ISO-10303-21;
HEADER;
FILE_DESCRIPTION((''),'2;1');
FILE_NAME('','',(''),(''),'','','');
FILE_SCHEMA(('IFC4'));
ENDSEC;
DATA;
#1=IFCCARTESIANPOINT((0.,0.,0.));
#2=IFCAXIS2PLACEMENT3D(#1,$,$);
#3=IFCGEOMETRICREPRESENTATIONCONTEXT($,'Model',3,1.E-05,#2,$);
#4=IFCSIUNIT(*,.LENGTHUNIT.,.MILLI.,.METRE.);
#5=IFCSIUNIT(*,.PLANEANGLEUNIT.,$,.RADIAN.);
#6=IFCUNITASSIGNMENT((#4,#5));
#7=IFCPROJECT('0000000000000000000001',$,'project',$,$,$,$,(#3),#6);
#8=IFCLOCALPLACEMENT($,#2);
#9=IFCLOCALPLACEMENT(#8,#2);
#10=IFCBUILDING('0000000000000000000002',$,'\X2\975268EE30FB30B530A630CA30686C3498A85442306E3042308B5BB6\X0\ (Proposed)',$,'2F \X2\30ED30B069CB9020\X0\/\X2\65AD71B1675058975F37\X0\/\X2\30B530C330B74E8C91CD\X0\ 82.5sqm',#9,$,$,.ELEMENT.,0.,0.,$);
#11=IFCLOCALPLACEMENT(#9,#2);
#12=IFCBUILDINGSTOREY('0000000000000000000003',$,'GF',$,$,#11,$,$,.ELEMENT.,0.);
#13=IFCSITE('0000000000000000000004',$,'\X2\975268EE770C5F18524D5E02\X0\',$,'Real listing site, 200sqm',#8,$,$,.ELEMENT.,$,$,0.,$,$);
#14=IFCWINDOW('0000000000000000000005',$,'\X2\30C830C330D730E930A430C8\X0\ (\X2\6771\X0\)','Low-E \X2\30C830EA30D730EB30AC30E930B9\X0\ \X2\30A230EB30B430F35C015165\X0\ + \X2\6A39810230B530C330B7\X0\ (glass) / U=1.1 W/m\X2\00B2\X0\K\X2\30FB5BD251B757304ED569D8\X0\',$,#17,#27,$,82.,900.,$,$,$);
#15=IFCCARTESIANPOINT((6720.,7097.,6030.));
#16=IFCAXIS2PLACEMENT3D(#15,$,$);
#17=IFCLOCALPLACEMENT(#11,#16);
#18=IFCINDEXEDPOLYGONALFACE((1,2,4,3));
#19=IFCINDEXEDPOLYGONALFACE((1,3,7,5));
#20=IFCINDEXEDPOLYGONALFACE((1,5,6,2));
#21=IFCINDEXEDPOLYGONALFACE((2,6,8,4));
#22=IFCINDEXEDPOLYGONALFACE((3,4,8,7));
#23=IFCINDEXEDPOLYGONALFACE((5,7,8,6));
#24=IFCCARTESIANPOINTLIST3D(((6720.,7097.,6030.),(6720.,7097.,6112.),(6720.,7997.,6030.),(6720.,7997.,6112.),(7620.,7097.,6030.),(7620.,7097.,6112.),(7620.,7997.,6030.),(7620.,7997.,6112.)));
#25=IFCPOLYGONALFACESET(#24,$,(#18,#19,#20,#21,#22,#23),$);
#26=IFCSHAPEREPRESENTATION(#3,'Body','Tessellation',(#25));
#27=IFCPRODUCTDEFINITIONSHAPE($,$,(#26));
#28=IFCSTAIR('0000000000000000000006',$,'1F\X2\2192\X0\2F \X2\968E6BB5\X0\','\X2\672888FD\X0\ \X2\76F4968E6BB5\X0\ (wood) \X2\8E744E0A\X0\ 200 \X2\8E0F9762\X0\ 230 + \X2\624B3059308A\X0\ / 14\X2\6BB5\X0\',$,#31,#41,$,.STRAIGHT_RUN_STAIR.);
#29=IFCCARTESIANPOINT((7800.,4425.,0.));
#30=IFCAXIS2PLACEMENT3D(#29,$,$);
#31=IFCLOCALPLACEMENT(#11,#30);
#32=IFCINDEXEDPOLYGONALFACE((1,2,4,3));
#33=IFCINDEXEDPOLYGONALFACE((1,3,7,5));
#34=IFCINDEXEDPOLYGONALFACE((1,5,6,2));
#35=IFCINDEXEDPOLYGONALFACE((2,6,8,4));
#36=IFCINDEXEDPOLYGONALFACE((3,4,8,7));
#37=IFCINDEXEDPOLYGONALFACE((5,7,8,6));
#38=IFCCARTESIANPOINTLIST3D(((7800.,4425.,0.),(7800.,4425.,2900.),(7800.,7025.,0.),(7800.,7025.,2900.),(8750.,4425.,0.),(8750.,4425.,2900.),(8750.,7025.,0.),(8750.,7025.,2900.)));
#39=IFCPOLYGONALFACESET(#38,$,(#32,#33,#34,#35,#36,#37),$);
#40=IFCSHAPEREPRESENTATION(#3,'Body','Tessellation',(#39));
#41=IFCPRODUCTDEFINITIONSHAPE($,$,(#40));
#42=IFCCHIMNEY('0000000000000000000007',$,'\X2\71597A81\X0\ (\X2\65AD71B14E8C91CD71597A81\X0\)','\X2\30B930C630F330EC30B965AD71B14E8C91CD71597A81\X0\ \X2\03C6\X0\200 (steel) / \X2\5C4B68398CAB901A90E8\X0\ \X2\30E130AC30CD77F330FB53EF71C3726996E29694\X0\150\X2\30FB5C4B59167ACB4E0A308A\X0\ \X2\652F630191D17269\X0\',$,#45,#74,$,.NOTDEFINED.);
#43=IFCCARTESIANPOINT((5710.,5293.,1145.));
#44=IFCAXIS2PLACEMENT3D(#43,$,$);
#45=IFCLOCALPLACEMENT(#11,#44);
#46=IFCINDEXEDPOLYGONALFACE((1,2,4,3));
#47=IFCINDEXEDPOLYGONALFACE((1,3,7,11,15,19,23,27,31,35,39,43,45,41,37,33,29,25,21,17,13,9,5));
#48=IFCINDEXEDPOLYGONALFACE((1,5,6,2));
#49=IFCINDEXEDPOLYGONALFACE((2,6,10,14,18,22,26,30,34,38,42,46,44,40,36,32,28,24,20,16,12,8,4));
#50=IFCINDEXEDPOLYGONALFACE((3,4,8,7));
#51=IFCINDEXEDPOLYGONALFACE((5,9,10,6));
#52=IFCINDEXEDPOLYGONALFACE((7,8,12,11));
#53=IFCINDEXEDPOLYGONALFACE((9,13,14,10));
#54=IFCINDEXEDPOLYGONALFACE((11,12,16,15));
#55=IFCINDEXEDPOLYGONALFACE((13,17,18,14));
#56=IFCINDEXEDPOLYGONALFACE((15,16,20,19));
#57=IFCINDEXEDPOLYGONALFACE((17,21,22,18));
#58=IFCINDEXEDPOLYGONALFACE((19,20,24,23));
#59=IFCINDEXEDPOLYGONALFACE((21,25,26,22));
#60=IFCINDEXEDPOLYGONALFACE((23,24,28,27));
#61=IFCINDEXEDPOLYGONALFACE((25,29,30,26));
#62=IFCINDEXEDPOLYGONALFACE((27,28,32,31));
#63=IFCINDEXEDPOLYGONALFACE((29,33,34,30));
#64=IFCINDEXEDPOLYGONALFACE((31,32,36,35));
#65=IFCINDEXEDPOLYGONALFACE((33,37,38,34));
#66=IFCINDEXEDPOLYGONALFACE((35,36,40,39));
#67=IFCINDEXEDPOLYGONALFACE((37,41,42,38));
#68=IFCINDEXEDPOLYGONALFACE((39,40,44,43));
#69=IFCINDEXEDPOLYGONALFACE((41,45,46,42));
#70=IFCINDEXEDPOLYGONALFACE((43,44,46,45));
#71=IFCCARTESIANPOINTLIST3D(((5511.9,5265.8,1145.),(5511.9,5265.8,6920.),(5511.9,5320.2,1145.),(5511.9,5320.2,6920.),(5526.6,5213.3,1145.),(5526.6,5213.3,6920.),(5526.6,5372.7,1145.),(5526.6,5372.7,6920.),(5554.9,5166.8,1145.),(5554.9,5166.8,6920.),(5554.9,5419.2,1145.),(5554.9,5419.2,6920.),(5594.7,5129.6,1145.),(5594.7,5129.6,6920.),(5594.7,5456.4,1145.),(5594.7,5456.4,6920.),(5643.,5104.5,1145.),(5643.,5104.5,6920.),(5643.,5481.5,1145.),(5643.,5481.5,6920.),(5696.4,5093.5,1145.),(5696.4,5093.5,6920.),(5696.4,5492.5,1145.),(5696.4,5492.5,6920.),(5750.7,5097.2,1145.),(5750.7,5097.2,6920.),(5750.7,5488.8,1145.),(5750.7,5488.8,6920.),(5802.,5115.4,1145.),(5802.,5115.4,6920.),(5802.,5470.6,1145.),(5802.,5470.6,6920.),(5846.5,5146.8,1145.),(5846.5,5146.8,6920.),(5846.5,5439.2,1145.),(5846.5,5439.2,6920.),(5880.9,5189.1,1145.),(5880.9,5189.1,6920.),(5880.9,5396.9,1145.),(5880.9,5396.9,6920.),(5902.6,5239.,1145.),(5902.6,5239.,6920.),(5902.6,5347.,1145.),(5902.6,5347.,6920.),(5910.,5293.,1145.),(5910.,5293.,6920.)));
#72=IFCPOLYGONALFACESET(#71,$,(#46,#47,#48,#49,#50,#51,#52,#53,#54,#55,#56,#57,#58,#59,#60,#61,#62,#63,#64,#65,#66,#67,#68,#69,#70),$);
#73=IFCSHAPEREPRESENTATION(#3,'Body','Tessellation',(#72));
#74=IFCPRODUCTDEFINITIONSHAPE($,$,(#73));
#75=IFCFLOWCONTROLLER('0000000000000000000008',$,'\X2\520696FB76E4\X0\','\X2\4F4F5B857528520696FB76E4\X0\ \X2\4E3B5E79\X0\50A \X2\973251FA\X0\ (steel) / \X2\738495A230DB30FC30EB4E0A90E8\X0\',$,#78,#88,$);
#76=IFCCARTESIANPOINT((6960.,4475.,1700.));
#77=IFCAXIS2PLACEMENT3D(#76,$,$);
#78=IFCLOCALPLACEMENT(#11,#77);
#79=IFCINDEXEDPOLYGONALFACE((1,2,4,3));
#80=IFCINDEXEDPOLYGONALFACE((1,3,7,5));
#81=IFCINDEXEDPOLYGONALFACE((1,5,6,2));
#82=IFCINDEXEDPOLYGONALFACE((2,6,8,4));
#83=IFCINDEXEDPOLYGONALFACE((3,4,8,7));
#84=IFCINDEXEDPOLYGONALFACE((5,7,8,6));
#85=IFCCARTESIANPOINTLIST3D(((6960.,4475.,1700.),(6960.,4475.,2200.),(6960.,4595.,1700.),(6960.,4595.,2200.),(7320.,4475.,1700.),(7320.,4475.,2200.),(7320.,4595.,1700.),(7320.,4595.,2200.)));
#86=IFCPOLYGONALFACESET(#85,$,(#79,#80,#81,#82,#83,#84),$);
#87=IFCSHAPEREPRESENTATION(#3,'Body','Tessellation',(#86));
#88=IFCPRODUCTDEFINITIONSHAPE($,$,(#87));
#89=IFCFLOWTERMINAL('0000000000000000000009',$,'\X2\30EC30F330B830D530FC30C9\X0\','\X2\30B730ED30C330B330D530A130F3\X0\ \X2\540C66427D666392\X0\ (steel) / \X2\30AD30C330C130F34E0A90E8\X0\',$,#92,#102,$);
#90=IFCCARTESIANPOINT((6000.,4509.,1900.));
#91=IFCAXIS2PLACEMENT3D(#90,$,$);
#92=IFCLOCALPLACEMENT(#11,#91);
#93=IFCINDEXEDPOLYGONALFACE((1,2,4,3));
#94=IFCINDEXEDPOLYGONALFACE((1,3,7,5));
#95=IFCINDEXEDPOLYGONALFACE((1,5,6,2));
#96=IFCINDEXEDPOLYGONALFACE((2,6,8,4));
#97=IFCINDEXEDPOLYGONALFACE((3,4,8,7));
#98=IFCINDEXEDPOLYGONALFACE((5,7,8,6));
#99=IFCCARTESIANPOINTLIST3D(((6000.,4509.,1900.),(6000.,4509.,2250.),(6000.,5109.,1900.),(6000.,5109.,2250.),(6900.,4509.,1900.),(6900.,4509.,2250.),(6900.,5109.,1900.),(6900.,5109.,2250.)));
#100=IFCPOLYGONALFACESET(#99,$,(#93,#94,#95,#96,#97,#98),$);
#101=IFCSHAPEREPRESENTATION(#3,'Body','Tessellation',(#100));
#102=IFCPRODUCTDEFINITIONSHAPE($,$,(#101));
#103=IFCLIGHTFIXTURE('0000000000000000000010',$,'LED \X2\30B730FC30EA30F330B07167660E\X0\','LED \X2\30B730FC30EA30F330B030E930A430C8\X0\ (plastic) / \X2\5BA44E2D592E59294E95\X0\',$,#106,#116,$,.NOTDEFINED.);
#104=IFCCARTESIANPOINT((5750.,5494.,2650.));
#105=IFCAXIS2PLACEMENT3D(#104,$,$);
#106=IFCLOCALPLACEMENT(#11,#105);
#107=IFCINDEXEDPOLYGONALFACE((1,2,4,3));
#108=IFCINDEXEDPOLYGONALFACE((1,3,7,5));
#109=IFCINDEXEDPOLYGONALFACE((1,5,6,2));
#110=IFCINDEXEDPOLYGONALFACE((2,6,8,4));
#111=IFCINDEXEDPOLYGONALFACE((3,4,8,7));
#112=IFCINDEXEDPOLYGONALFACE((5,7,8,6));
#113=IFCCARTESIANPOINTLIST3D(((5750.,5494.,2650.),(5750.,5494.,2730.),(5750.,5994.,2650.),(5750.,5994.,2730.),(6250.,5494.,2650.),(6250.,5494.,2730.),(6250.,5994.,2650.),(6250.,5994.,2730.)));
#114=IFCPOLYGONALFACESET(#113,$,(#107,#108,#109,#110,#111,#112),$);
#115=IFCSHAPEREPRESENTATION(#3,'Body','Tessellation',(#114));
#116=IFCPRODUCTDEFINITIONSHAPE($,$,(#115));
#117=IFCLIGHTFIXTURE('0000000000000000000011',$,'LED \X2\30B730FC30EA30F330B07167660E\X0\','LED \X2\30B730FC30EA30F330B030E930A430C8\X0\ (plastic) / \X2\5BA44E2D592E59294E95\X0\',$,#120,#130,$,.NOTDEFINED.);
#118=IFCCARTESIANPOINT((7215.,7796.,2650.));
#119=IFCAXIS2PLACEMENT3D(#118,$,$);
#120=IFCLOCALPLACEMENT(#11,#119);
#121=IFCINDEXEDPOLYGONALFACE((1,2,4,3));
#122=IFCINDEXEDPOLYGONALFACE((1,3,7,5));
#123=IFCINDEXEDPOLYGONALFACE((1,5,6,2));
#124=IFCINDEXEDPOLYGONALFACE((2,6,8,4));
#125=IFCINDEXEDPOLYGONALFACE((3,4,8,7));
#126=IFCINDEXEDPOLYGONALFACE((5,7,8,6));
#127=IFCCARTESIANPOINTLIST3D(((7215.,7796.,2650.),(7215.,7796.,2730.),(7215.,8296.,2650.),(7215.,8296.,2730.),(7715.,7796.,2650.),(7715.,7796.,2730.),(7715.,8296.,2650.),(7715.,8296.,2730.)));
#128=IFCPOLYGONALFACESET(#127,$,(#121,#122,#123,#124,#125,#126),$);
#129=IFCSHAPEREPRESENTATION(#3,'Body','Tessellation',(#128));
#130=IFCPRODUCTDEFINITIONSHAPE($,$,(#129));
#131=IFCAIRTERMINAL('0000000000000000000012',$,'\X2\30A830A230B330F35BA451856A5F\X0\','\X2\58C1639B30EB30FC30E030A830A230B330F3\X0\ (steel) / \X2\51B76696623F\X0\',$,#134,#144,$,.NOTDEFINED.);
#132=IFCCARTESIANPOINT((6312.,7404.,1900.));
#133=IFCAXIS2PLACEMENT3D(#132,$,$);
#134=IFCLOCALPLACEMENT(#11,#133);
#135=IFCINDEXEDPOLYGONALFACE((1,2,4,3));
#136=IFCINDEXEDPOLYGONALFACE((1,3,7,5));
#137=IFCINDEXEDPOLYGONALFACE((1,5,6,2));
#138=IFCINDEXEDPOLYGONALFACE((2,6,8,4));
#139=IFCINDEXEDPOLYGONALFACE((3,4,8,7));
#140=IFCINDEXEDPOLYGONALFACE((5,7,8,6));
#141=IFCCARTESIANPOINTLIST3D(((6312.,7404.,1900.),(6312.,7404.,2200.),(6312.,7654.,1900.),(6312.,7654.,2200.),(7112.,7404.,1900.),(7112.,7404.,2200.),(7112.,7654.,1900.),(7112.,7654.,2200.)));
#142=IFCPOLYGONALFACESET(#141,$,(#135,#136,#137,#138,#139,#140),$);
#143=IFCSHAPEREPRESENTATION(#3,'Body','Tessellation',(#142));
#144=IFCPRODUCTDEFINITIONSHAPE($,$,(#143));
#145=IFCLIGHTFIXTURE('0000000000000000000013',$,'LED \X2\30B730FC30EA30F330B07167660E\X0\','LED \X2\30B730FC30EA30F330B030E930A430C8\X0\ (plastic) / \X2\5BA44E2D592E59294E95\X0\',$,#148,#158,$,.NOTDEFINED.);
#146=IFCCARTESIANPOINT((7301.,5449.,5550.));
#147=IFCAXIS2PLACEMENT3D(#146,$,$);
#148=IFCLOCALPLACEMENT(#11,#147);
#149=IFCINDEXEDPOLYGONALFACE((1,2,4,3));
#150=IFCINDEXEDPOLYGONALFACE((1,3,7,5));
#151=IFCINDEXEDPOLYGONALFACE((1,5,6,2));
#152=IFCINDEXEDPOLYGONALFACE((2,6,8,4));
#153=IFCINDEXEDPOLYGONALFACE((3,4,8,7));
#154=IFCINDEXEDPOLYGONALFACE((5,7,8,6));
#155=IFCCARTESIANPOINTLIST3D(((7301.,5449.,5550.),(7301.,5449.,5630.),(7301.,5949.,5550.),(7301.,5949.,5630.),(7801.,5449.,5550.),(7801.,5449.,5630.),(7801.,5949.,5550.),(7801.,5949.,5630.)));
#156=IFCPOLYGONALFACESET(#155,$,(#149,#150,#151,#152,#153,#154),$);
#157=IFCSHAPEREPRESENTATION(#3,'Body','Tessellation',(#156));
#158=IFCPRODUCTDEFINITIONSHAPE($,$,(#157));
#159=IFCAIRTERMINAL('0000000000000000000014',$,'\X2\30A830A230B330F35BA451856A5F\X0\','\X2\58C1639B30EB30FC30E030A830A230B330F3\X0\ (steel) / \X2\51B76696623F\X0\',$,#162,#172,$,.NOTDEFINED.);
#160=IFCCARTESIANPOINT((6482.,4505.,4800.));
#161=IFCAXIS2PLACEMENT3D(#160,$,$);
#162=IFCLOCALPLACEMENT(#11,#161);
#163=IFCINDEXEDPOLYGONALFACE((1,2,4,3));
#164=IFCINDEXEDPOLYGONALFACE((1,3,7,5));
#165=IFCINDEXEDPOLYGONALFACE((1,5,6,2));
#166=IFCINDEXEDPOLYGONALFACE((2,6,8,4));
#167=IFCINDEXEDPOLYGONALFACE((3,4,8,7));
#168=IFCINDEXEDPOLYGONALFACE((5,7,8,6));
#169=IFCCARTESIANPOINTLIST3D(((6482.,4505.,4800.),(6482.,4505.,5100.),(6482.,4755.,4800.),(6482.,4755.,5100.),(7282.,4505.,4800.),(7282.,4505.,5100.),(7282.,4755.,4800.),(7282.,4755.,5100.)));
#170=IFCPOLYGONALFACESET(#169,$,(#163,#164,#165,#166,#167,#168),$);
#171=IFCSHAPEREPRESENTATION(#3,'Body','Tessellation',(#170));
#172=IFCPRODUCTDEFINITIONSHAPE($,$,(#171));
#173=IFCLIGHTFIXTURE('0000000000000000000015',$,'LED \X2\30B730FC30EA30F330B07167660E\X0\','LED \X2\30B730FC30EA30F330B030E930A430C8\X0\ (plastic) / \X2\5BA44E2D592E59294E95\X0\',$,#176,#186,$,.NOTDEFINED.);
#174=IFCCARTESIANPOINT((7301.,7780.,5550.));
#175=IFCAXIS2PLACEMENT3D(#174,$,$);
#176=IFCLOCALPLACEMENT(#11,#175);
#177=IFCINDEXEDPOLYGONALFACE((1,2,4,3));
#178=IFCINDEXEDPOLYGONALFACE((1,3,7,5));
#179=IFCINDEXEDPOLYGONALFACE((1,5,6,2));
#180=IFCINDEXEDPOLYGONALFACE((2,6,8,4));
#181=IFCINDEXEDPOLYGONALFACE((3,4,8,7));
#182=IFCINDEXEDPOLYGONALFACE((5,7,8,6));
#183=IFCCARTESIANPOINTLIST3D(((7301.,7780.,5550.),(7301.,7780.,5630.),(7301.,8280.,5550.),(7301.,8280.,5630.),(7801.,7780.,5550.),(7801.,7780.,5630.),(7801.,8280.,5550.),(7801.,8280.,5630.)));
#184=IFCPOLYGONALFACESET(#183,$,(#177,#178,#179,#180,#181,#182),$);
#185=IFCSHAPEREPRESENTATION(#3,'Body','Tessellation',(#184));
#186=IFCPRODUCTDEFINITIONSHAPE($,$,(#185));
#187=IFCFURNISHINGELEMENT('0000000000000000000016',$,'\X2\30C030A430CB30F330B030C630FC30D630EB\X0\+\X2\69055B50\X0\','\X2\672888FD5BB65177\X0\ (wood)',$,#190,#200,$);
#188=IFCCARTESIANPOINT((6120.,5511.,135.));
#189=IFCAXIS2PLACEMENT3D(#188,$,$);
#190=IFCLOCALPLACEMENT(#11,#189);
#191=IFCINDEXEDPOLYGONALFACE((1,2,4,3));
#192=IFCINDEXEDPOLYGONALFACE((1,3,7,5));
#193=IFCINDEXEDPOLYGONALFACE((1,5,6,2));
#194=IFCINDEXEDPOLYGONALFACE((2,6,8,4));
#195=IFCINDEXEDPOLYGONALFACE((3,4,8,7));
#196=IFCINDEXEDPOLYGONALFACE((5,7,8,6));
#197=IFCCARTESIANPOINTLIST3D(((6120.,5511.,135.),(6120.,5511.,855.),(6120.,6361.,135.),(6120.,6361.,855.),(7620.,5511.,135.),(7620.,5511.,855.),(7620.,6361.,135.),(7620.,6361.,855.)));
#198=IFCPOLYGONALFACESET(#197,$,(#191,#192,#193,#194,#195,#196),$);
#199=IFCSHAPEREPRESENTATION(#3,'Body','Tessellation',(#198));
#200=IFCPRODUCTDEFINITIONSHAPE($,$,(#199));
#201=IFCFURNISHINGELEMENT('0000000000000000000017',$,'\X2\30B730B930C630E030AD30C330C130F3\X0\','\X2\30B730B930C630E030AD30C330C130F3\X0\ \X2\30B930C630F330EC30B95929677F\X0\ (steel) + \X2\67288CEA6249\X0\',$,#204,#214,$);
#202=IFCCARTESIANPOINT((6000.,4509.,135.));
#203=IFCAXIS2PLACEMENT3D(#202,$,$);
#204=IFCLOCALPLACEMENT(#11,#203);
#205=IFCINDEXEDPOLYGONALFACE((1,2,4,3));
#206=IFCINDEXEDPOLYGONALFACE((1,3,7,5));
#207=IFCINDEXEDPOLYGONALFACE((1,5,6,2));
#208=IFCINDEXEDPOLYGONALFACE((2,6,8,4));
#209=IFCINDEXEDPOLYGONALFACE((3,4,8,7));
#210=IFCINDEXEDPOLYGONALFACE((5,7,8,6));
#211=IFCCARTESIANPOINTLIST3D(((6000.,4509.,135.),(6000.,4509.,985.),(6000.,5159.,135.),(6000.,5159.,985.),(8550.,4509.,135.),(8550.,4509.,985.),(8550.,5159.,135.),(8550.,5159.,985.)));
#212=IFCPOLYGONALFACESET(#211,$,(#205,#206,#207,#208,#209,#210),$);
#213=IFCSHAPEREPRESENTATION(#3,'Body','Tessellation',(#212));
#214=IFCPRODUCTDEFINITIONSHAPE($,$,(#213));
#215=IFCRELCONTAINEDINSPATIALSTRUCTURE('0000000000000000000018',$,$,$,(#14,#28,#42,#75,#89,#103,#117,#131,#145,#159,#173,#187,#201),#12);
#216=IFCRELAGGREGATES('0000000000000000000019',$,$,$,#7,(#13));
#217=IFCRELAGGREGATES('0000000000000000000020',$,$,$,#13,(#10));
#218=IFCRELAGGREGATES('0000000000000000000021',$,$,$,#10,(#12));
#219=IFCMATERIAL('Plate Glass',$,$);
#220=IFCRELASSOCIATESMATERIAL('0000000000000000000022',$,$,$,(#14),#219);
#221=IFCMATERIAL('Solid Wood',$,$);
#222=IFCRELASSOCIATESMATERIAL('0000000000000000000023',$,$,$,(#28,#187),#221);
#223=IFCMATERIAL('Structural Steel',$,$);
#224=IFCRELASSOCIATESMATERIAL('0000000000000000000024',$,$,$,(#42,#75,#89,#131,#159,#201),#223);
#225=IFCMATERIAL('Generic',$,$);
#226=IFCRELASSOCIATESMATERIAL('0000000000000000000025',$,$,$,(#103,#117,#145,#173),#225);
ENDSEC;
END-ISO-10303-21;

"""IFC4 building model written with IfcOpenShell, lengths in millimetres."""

from ifc_helpers import new_model, si_unit, frame, frame_2d, origin, origin_2d, place, context, project, spatial, rectangle, circle, extrude, material, element, save


model = new_model("IFC4")

# Units and contexts
model_context = context("Model", 3, precision=1e-05, world=origin())
ifc_project = project(units=[si_unit("LENGTHUNIT", "METRE", prefix="MILLI"), si_unit("PLANEANGLEUNIT", "RADIAN")], contexts=[model_context])

# Site, building, storey
site_placement = place(None, origin())
site = spatial("IfcSite", under=ifc_project, at=site_placement, Name="青森県弘前市", ObjectType="Real listing site, 200sqm", CompositionType="ELEMENT", RefElevation=0.0)
building_placement = place(site_placement, origin())
building = spatial("IfcBuilding", under=site, at=building_placement, Name="青森・サウナと水風呂のある家 (Proposed)", ObjectType="2F ログ構造/断熱材増強/サッシ二重 82.5sqm", CompositionType="ELEMENT", ElevationOfRefHeight=0.0, ElevationOfTerrain=0.0)
storey_placement = place(building_placement, origin())
storey = spatial("IfcBuildingStorey", under=building, at=storey_placement, Name="GF", CompositionType="ELEMENT", Elevation=0.0)

# Shared definitions
ifc_material_1 = material(Name="Solid Wood")

# Window
ifc_material_2 = material(Name="Plate Glass")
window_placement = place(storey_placement, frame((6720.0, 7097.0, 6030.0)))
element("IfcWindow", 1, at=window_placement, inside=storey, material=ifc_material_2, Name="トップライト (東)", Description="Low-E トリプルガラス アルゴン封入 + 樹脂サッシ (glass) / U=1.1 W/m²K・寒冷地仕様", OverallHeight=82.0, OverallWidth=900.0, context=model_context, shape_type="SweptSolid", body=[
    extrude(rectangle(XDim=900.0, YDim=900.0, at=frame_2d((450.0, 450.0))), frame((6720.0, 7097.0, 6030.0)), (0.0, 0.0, 1.0), 82.0),
])

# Stair
stair_placement = place(storey_placement, frame((7800.0, 4425.0, 0.0)))
element("IfcStair", 2, at=stair_placement, inside=storey, material=ifc_material_1, Name="1F→2F 階段", Description="木製 直階段 (wood) 蹴上 200 踏面 230 + 手すり / 14段", PredefinedType="STRAIGHT_RUN_STAIR", context=model_context, shape_type="SweptSolid", body=[
    extrude(rectangle(XDim=950.0, YDim=2600.0, at=frame_2d((475.0, 1300.0))), frame((7800.0, 4425.0, 0.0)), (0.0, 0.0, 1.0), 2900.0),
])

# Chimney
ifc_material_3 = material(Name="Structural Steel")
chimney_placement = place(storey_placement, frame((5710.0, 5293.0, 1145.0)))
element("IfcChimney", 3, at=chimney_placement, inside=storey, material=ifc_material_3, Name="煙突 (断熱二重煙突)", Description="ステンレス断熱二重煙突 φ200 (steel) / 屋根貫通部 メガネ石・可燃物離隔150・屋外立上り 支持金物", PredefinedType="NOTDEFINED", context=model_context, shape_type="SweptSolid", body=[
    extrude(circle(Radius=200.0, at=origin_2d()), frame((5710.0, 5293.0, 1145.0)), (0.0, 0.0, 1.0), 5775.0),
])

# Flow controller
flow_controller_placement = place(storey_placement, frame((6960.0, 4475.0, 1700.0)))
element("IfcFlowController", 4, at=flow_controller_placement, inside=storey, material=ifc_material_3, Name="分電盤", Description="住宅用分電盤 主幹50A 露出 (steel) / 玄関ホール上部", context=model_context, shape_type="SweptSolid", body=[
    extrude(rectangle(XDim=360.0, YDim=120.0, at=frame_2d((180.0, 60.0))), frame((6960.0, 4475.0, 1700.0)), (0.0, 0.0, 1.0), 500.0),
])

# Flow terminal
flow_terminal_placement = place(storey_placement, frame((6000.0, 4509.0, 1900.0)))
element("IfcFlowTerminal", 5, at=flow_terminal_placement, inside=storey, material=ifc_material_3, Name="レンジフード", Description="シロッコファン 同時給排 (steel) / キッチン上部", context=model_context, shape_type="SweptSolid", body=[
    extrude(rectangle(XDim=900.0, YDim=600.0, at=frame_2d((450.0, 300.0))), frame((6000.0, 4509.0, 1900.0)), (0.0, 0.0, 1.0), 350.0),
])

# Light fixtures
ifc_material_4 = material(Name="Generic")
light_fixture_1_placement = place(storey_placement, frame((5750.0, 5494.0, 2650.0)))
element("IfcLightFixture", 6, at=light_fixture_1_placement, inside=storey, material=ifc_material_4, Name="LED シーリング照明", Description="LED シーリングライト (plastic) / 室中央天井", PredefinedType="NOTDEFINED", context=model_context, shape_type="SweptSolid", body=[
    extrude(rectangle(XDim=500.0, YDim=500.0, at=frame_2d((250.0, 250.0))), frame((5750.0, 5494.0, 2650.0)), (0.0, 0.0, 1.0), 80.0),
])
light_fixture_2_placement = place(storey_placement, frame((7215.0, 7796.0, 2650.0)))
element("IfcLightFixture", 7, at=light_fixture_2_placement, inside=storey, material=ifc_material_4, Name="LED シーリング照明", Description="LED シーリングライト (plastic) / 室中央天井", PredefinedType="NOTDEFINED", context=model_context, shape_type="SweptSolid", body=[
    extrude(rectangle(XDim=500.0, YDim=500.0, at=frame_2d((250.0, 250.0))), frame((7215.0, 7796.0, 2650.0)), (0.0, 0.0, 1.0), 80.0),
])

# Air terminal
air_terminal_1_placement = place(storey_placement, frame((6312.0, 7404.0, 1900.0)))
element("IfcAirTerminal", 8, at=air_terminal_1_placement, inside=storey, material=ifc_material_3, Name="エアコン室内機", Description="壁掛ルームエアコン (steel) / 冷暖房", PredefinedType="NOTDEFINED", context=model_context, shape_type="SweptSolid", body=[
    extrude(rectangle(XDim=800.0, YDim=250.0, at=frame_2d((400.0, 125.0))), frame((6312.0, 7404.0, 1900.0)), (0.0, 0.0, 1.0), 300.0),
])

# Light fixture
light_fixture_3_placement = place(storey_placement, frame((7301.0, 5449.0, 5550.0)))
element("IfcLightFixture", 9, at=light_fixture_3_placement, inside=storey, material=ifc_material_4, Name="LED シーリング照明", Description="LED シーリングライト (plastic) / 室中央天井", PredefinedType="NOTDEFINED", context=model_context, shape_type="SweptSolid", body=[
    extrude(rectangle(XDim=500.0, YDim=500.0, at=frame_2d((250.0, 250.0))), frame((7301.0, 5449.0, 5550.0)), (0.0, 0.0, 1.0), 80.0),
])

# Air terminal
air_terminal_2_placement = place(storey_placement, frame((6482.0, 4505.0, 4800.0)))
element("IfcAirTerminal", 10, at=air_terminal_2_placement, inside=storey, material=ifc_material_3, Name="エアコン室内機", Description="壁掛ルームエアコン (steel) / 冷暖房", PredefinedType="NOTDEFINED", context=model_context, shape_type="SweptSolid", body=[
    extrude(rectangle(XDim=800.0, YDim=250.0, at=frame_2d((400.0, 125.0))), frame((6482.0, 4505.0, 4800.0)), (0.0, 0.0, 1.0), 300.0),
])

# Light fixture
light_fixture_4_placement = place(storey_placement, frame((7301.0, 7780.0, 5550.0)))
element("IfcLightFixture", 11, at=light_fixture_4_placement, inside=storey, material=ifc_material_4, Name="LED シーリング照明", Description="LED シーリングライト (plastic) / 室中央天井", PredefinedType="NOTDEFINED", context=model_context, shape_type="SweptSolid", body=[
    extrude(rectangle(XDim=500.0, YDim=500.0, at=frame_2d((250.0, 250.0))), frame((7301.0, 7780.0, 5550.0)), (0.0, 0.0, 1.0), 80.0),
])

# Furnishing elements
furnishing_1_placement = place(storey_placement, frame((6120.0, 5511.0, 135.0)))
element("IfcFurnishingElement", 12, at=furnishing_1_placement, inside=storey, material=ifc_material_1, Name="ダイニングテーブル+椅子", Description="木製家具 (wood)", context=model_context, shape_type="SweptSolid", body=[
    extrude(rectangle(XDim=1500.0, YDim=850.0, at=frame_2d((750.0, 425.0))), frame((6120.0, 5511.0, 135.0)), (0.0, 0.0, 1.0), 720.0),
])
furnishing_2_placement = place(storey_placement, frame((6000.0, 4509.0, 135.0)))
element("IfcFurnishingElement", 13, at=furnishing_2_placement, inside=storey, material=ifc_material_3, Name="システムキッチン", Description="システムキッチン ステンレス天板 (steel) + 木質扉", context=model_context, shape_type="SweptSolid", body=[
    extrude(rectangle(XDim=2550.0, YDim=650.0, at=frame_2d((1275.0, 325.0))), frame((6000.0, 4509.0, 135.0)), (0.0, 0.0, 1.0), 850.0),
])

save(model, "model.ifc")
